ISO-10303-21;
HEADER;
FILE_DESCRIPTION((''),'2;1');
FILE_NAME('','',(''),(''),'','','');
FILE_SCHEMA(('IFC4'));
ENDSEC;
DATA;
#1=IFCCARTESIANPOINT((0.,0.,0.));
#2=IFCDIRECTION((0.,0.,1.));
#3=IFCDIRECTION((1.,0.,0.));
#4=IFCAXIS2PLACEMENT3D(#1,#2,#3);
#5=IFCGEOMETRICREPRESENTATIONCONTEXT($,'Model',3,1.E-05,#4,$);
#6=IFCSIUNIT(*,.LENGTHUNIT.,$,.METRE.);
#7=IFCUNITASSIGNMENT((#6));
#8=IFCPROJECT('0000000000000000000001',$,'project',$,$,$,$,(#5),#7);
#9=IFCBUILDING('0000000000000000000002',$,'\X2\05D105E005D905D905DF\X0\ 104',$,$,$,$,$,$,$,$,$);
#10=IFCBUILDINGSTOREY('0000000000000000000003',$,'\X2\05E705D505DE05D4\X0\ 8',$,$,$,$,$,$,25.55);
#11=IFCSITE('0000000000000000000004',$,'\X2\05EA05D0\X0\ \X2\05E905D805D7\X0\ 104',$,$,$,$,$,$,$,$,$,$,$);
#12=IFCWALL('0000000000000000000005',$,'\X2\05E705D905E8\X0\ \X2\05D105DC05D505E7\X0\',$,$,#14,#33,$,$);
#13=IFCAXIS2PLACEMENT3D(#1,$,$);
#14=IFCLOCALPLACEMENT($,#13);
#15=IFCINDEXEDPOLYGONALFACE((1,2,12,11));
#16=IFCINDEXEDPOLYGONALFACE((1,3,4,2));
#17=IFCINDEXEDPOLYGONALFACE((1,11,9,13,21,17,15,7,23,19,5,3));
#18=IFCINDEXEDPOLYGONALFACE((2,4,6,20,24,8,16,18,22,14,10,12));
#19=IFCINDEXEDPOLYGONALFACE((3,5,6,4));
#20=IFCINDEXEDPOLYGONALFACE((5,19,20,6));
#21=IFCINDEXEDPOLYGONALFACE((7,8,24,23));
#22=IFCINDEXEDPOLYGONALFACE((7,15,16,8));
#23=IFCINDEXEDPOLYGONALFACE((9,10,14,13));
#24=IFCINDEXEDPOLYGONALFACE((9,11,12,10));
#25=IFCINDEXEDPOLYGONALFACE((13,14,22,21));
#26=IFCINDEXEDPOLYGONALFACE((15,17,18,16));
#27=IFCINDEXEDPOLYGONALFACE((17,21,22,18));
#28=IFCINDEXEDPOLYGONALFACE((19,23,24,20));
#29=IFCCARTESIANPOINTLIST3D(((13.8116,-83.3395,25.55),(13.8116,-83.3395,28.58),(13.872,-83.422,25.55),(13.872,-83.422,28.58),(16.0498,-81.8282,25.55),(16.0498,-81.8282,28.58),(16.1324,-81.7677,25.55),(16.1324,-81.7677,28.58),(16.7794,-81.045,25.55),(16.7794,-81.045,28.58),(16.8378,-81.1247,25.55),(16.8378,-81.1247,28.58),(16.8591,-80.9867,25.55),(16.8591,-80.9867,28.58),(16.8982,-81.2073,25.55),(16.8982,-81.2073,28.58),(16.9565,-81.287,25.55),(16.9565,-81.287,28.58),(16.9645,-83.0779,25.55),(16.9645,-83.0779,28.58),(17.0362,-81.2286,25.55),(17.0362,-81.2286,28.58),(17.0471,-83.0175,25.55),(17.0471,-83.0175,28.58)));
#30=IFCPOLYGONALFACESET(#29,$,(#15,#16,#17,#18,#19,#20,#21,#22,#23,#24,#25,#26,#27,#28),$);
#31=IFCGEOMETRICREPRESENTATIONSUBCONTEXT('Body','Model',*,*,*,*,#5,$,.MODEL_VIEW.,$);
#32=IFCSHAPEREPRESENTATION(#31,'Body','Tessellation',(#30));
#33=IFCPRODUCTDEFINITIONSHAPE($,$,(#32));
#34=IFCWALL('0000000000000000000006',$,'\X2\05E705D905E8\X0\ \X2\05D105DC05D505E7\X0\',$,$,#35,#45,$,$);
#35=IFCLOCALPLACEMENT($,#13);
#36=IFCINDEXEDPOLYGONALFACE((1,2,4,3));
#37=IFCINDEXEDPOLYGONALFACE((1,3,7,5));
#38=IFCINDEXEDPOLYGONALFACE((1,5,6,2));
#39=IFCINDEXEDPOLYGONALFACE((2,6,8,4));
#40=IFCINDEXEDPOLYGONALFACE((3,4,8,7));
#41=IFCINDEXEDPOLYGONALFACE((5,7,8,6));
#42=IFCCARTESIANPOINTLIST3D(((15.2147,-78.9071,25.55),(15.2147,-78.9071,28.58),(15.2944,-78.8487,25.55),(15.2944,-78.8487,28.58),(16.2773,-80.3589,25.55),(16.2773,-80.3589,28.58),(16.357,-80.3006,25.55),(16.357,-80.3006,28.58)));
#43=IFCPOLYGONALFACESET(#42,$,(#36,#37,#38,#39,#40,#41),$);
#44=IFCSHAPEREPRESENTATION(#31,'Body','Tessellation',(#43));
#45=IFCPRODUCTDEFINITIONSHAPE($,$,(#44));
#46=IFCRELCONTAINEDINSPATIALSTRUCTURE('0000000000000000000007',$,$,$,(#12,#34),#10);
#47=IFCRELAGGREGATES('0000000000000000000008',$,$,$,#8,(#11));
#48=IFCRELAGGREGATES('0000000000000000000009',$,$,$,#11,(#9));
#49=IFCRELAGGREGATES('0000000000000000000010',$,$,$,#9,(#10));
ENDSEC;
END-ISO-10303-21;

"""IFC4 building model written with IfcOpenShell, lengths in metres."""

from ifc_helpers import new_model, si_unit, frame, origin_with_axes, context, subcontext, project, spatial, polyline, outline, extrude, element, save


model = new_model("IFC4")

# Units and contexts
model_context = context("Model", 3, precision=1e-05, world=origin_with_axes())
body_context = subcontext(model_context, "Body", "Model", "MODEL_VIEW")
ifc_project = project(units=[si_unit("LENGTHUNIT", "METRE")], contexts=[model_context])

# Site, building, storey
site = spatial("IfcSite", under=ifc_project, Name="תא שטח 104")
building = spatial("IfcBuilding", under=site, Name="בניין 104")
storey = spatial("IfcBuildingStorey", under=building, Name="קומה 8", Elevation=25.55)

# Walls
element("IfcWall", 1, inside=storey, Name="קיר בלוק", context=body_context, shape_type="SweptSolid", body=[
    extrude(outline(polyline([(16.8378, -81.1247), (13.8116, -83.3395), (13.872, -83.422), (16.0498, -81.8282), (16.9645, -83.0779), (17.0471, -83.0175), (16.1324, -81.7677), (16.8982, -81.2073), (16.9565, -81.287), (17.0362, -81.2286), (16.8591, -80.9867), (16.7794, -81.045), (16.8378, -81.1247)])), frame((0.0, 0.0, 25.55)), (0.0, 0.0, 1.0), 3.03),
])
element("IfcWall", 2, inside=storey, Name="קיר בלוק", context=body_context, shape_type="SweptSolid", body=[
    extrude(outline(polyline([(16.357, -80.3006), (15.2944, -78.8487), (15.2147, -78.9071), (16.2773, -80.3589), (16.357, -80.3006)])), frame((0.0, 0.0, 25.55)), (0.0, 0.0, 1.0), 3.03),
])

save(model, "model.ifc")
